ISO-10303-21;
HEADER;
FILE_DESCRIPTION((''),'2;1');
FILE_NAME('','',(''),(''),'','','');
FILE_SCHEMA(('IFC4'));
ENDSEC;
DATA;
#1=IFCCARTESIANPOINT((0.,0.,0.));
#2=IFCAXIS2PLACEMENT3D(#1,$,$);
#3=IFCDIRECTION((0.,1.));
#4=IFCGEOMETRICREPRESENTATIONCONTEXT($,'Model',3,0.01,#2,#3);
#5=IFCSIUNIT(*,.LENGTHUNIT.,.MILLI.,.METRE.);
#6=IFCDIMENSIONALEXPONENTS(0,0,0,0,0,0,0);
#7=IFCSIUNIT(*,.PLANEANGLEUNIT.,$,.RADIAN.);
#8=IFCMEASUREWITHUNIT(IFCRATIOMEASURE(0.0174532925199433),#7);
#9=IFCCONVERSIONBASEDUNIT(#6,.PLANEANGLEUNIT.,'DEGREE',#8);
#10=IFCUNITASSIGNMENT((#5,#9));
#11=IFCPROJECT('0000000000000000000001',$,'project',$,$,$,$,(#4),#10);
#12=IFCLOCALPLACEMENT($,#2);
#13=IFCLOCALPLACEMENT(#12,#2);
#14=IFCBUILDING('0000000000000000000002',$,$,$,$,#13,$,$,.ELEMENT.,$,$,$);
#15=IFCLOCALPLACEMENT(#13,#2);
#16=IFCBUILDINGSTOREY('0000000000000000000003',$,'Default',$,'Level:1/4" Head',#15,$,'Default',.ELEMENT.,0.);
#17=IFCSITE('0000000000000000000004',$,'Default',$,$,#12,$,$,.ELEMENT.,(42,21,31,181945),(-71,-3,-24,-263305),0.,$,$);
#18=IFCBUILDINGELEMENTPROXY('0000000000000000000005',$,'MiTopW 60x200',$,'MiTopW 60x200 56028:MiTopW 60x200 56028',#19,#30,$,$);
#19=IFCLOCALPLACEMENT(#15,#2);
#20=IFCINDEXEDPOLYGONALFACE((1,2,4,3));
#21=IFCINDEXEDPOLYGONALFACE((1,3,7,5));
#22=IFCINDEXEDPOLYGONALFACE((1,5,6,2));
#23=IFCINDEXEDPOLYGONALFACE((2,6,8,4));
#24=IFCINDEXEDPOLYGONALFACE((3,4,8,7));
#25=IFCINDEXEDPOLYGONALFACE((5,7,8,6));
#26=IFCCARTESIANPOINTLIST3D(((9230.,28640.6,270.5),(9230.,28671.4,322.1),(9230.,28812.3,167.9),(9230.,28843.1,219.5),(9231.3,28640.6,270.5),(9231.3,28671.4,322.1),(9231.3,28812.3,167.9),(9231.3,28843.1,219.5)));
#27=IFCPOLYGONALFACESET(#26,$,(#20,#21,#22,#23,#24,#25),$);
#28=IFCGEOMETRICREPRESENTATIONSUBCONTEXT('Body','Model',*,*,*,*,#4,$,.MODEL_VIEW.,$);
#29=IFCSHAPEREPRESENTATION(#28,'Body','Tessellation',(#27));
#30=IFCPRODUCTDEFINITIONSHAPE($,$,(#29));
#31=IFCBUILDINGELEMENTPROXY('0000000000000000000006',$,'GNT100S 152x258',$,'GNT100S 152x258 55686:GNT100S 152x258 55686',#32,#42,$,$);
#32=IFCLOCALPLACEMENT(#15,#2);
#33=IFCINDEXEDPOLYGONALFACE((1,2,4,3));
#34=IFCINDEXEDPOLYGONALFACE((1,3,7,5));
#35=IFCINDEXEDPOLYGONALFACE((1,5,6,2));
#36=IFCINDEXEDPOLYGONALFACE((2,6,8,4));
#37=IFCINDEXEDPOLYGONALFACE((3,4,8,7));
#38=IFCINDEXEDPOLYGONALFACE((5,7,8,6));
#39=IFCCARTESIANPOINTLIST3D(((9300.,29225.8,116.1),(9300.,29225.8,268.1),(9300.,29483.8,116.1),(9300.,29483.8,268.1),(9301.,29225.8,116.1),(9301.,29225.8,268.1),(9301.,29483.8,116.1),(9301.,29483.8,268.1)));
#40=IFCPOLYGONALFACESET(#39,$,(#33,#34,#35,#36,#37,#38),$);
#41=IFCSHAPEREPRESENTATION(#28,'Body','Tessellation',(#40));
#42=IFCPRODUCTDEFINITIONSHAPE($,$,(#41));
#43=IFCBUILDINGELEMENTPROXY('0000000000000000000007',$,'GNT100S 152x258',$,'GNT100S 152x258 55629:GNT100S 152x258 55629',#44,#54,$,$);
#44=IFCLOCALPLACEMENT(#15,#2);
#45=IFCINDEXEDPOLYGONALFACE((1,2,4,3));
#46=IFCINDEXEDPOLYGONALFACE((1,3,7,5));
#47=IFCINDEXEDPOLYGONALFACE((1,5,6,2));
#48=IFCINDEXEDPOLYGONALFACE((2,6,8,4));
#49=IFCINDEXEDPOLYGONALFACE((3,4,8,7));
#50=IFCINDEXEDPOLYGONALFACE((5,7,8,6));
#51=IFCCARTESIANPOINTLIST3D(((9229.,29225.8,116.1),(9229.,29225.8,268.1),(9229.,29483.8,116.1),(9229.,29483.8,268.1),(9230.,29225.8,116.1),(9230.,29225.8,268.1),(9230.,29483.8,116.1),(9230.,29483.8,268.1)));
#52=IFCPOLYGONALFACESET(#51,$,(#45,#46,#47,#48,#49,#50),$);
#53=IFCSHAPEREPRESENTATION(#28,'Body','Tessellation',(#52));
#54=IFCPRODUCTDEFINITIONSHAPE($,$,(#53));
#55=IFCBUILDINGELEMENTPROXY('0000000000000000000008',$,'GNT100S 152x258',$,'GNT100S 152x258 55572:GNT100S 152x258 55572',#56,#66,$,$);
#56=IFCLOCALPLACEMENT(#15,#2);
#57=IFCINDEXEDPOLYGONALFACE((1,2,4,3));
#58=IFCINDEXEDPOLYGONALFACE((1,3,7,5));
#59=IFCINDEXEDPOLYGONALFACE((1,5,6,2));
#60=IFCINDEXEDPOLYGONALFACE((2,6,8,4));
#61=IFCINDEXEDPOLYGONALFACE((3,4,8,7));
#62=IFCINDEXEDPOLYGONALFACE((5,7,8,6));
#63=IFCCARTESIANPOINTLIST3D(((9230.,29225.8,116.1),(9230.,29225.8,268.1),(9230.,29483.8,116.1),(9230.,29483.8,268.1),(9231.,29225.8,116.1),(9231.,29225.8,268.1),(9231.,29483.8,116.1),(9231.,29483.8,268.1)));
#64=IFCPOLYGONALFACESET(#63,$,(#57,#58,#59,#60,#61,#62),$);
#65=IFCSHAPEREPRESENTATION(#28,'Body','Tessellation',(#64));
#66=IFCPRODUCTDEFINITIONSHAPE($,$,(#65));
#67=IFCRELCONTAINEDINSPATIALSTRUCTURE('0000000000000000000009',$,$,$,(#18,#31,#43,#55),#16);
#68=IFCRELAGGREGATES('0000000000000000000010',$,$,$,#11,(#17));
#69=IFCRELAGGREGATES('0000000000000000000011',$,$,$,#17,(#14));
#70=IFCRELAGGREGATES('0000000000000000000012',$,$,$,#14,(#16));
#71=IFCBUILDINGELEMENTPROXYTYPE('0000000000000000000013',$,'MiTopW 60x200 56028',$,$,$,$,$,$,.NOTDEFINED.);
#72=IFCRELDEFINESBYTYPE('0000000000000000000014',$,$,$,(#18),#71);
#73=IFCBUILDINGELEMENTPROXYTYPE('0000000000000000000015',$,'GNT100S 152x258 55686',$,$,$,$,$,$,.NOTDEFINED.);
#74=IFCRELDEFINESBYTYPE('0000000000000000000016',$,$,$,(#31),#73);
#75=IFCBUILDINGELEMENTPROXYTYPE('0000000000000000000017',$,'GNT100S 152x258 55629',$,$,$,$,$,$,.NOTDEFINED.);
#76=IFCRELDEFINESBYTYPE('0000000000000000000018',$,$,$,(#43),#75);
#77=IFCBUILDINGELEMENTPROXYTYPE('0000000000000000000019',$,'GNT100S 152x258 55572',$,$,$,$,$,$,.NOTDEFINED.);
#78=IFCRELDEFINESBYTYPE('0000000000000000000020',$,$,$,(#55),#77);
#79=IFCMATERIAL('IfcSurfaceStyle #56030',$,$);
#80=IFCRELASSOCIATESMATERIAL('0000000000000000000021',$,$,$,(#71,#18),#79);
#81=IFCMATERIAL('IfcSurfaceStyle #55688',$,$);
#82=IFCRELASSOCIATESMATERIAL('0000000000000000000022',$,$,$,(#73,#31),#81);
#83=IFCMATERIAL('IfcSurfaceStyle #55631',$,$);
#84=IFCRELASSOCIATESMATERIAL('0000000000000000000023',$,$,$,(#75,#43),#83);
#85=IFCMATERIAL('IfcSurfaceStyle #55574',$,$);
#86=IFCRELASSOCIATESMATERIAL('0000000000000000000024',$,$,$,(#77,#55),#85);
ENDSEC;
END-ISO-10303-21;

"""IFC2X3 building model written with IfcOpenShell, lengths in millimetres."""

from ifc_helpers import new_model, entity, si_unit, converted_unit, direction, frame, origin, origin_2d_with_axis, place, context, subcontext, project, spatial, polyline, rectangle, outline, extrude, source, transform, mapped, material, type_object, type_shapes, element, save


model = new_model("IFC2X3")

# Units and contexts
model_context = context("Model", 3, precision=0.01, world=origin(), true_north=direction((0.0, 1.0)))
body_context = subcontext(model_context, "Body", "Model", "MODEL_VIEW")
ifc_project = project(units=[si_unit("LENGTHUNIT", "METRE", prefix="MILLI"), converted_unit("PLANEANGLEUNIT", "DEGREE", entity("IfcRatioMeasure", 0.0174532925199433), si_unit("PLANEANGLEUNIT", "RADIAN"), dimensions=[0, 0, 0, 0, 0, 0, 0])], contexts=[model_context])

# Site, building, storey
site_placement = place(None, origin())
site = spatial("IfcSite", under=ifc_project, at=site_placement, Name="Default", CompositionType="ELEMENT", RefLatitude=(42, 21, 31, 181945), RefLongitude=(-71, -3, -24, -263305), RefElevation=0.0)
building_placement = place(site_placement, origin())
building = spatial("IfcBuilding", under=site, at=building_placement, CompositionType="ELEMENT")
storey_placement = place(building_placement, origin())
storey = spatial("IfcBuildingStorey", under=building, at=storey_placement, Name="Default", ObjectType="Level:1/4\" Head", LongName="Default", CompositionType="ELEMENT", Elevation=0.0)

# Building element proxies
ifc_material_1 = material(Name="IfcSurfaceStyle #56030")
building_element_proxy_type_1 = type_object("IfcBuildingElementProxyType", Name="MiTopW 60x200 56028", PredefinedType="NOTDEFINED", material=ifc_material_1)
shared_shape_1 = source(origin(), body_context, "Body", "SweptSolid", [
    extrude(outline(polyline([(-100.0, -30.0), (100.0, -30.0), (100.0, 30.0), (-100.0, 30.0), (-100.0, -30.0)])), frame((100.0, 30.0, 0.0), z_axis=(0.0, 0.0, 1.0), x_axis=(-1.0, 0.0, 0.0)), (0.0, 0.0, 1.0), 1.3),
])
type_shapes(building_element_proxy_type_1, [shared_shape_1])
proxy_1_placement = place(building_placement, frame((9231.3, 28812.3, 167.9), z_axis=(-1.0, 0.0, 0.0), x_axis=(0.0, -0.858392, 0.512994)))
element("IfcBuildingElementProxy", 1, at=proxy_1_placement, inside=storey, type_object=building_element_proxy_type_1, material=ifc_material_1, Name="MiTopW 60x200", ObjectType="MiTopW 60x200 56028:MiTopW 60x200 56028", context=body_context, shape_type="MappedRepresentation", body=[
    mapped(shared_shape_1, transform((0.0, 0.0, 0.0), scale=1.0)),
])
ifc_material_2 = material(Name="IfcSurfaceStyle #55688")
building_element_proxy_type_2 = type_object("IfcBuildingElementProxyType", Name="GNT100S 152x258 55686", PredefinedType="NOTDEFINED", material=ifc_material_2)
shared_shape_2 = source(origin(), body_context, "Body", "SweptSolid", [
    extrude(rectangle(XDim=258.0, YDim=152.0, at=origin_2d_with_axis()), frame((129.0, 76.0, 0.0), z_axis=(0.0, 0.0, 1.0), x_axis=(-1.0, 0.0, 0.0)), (0.0, 0.0, 1.0), 1.0),
])
type_shapes(building_element_proxy_type_2, [shared_shape_2])
proxy_2_placement = place(building_placement, frame((9301.0, 29483.8, 116.1), z_axis=(-1.0, 0.0, 0.0), x_axis=(0.0, -1.0, 0.0)))
element("IfcBuildingElementProxy", 2, at=proxy_2_placement, inside=storey, type_object=building_element_proxy_type_2, material=ifc_material_2, Name="GNT100S 152x258", ObjectType="GNT100S 152x258 55686:GNT100S 152x258 55686", context=body_context, shape_type="MappedRepresentation", body=[
    mapped(shared_shape_2, transform((0.0, 0.0, 0.0), scale=1.0)),
])
ifc_material_3 = material(Name="IfcSurfaceStyle #55631")
building_element_proxy_type_3 = type_object("IfcBuildingElementProxyType", Name="GNT100S 152x258 55629", PredefinedType="NOTDEFINED", material=ifc_material_3)
shared_shape_3 = source(origin(), body_context, "Body", "SweptSolid", [
    extrude(rectangle(XDim=258.0, YDim=152.0, at=origin_2d_with_axis()), frame((129.0, 76.0, 0.0), z_axis=(0.0, 0.0, 1.0), x_axis=(-1.0, 0.0, 0.0)), (0.0, 0.0, 1.0), 1.0),
])
type_shapes(building_element_proxy_type_3, [shared_shape_3])
proxy_3_placement = place(building_placement, frame((9230.0, 29483.8, 116.1), z_axis=(-1.0, 0.0, 0.0), x_axis=(0.0, -1.0, 0.0)))
element("IfcBuildingElementProxy", 3, at=proxy_3_placement, inside=storey, type_object=building_element_proxy_type_3, material=ifc_material_3, Name="GNT100S 152x258", ObjectType="GNT100S 152x258 55629:GNT100S 152x258 55629", context=body_context, shape_type="MappedRepresentation", body=[
    mapped(shared_shape_3, transform((0.0, 0.0, 0.0), scale=1.0)),
])
ifc_material_4 = material(Name="IfcSurfaceStyle #55574")
building_element_proxy_type_4 = type_object("IfcBuildingElementProxyType", Name="GNT100S 152x258 55572", PredefinedType="NOTDEFINED", material=ifc_material_4)
shared_shape_4 = source(origin(), body_context, "Body", "SweptSolid", [
    extrude(rectangle(XDim=258.0, YDim=152.0, at=origin_2d_with_axis()), frame((129.0, 76.0, 0.0), z_axis=(0.0, 0.0, 1.0), x_axis=(-1.0, 0.0, 0.0)), (0.0, 0.0, 1.0), 1.0),
])
type_shapes(building_element_proxy_type_4, [shared_shape_4])
proxy_4_placement = place(building_placement, frame((9231.0, 29483.8, 116.1), z_axis=(-1.0, 0.0, 0.0), x_axis=(0.0, -1.0, 0.0)))
element("IfcBuildingElementProxy", 4, at=proxy_4_placement, inside=storey, type_object=building_element_proxy_type_4, material=ifc_material_4, Name="GNT100S 152x258", ObjectType="GNT100S 152x258 55572:GNT100S 152x258 55572", context=body_context, shape_type="MappedRepresentation", body=[
    mapped(shared_shape_4, transform((0.0, 0.0, 0.0), scale=1.0)),
])

save(model, "model.ifc")
